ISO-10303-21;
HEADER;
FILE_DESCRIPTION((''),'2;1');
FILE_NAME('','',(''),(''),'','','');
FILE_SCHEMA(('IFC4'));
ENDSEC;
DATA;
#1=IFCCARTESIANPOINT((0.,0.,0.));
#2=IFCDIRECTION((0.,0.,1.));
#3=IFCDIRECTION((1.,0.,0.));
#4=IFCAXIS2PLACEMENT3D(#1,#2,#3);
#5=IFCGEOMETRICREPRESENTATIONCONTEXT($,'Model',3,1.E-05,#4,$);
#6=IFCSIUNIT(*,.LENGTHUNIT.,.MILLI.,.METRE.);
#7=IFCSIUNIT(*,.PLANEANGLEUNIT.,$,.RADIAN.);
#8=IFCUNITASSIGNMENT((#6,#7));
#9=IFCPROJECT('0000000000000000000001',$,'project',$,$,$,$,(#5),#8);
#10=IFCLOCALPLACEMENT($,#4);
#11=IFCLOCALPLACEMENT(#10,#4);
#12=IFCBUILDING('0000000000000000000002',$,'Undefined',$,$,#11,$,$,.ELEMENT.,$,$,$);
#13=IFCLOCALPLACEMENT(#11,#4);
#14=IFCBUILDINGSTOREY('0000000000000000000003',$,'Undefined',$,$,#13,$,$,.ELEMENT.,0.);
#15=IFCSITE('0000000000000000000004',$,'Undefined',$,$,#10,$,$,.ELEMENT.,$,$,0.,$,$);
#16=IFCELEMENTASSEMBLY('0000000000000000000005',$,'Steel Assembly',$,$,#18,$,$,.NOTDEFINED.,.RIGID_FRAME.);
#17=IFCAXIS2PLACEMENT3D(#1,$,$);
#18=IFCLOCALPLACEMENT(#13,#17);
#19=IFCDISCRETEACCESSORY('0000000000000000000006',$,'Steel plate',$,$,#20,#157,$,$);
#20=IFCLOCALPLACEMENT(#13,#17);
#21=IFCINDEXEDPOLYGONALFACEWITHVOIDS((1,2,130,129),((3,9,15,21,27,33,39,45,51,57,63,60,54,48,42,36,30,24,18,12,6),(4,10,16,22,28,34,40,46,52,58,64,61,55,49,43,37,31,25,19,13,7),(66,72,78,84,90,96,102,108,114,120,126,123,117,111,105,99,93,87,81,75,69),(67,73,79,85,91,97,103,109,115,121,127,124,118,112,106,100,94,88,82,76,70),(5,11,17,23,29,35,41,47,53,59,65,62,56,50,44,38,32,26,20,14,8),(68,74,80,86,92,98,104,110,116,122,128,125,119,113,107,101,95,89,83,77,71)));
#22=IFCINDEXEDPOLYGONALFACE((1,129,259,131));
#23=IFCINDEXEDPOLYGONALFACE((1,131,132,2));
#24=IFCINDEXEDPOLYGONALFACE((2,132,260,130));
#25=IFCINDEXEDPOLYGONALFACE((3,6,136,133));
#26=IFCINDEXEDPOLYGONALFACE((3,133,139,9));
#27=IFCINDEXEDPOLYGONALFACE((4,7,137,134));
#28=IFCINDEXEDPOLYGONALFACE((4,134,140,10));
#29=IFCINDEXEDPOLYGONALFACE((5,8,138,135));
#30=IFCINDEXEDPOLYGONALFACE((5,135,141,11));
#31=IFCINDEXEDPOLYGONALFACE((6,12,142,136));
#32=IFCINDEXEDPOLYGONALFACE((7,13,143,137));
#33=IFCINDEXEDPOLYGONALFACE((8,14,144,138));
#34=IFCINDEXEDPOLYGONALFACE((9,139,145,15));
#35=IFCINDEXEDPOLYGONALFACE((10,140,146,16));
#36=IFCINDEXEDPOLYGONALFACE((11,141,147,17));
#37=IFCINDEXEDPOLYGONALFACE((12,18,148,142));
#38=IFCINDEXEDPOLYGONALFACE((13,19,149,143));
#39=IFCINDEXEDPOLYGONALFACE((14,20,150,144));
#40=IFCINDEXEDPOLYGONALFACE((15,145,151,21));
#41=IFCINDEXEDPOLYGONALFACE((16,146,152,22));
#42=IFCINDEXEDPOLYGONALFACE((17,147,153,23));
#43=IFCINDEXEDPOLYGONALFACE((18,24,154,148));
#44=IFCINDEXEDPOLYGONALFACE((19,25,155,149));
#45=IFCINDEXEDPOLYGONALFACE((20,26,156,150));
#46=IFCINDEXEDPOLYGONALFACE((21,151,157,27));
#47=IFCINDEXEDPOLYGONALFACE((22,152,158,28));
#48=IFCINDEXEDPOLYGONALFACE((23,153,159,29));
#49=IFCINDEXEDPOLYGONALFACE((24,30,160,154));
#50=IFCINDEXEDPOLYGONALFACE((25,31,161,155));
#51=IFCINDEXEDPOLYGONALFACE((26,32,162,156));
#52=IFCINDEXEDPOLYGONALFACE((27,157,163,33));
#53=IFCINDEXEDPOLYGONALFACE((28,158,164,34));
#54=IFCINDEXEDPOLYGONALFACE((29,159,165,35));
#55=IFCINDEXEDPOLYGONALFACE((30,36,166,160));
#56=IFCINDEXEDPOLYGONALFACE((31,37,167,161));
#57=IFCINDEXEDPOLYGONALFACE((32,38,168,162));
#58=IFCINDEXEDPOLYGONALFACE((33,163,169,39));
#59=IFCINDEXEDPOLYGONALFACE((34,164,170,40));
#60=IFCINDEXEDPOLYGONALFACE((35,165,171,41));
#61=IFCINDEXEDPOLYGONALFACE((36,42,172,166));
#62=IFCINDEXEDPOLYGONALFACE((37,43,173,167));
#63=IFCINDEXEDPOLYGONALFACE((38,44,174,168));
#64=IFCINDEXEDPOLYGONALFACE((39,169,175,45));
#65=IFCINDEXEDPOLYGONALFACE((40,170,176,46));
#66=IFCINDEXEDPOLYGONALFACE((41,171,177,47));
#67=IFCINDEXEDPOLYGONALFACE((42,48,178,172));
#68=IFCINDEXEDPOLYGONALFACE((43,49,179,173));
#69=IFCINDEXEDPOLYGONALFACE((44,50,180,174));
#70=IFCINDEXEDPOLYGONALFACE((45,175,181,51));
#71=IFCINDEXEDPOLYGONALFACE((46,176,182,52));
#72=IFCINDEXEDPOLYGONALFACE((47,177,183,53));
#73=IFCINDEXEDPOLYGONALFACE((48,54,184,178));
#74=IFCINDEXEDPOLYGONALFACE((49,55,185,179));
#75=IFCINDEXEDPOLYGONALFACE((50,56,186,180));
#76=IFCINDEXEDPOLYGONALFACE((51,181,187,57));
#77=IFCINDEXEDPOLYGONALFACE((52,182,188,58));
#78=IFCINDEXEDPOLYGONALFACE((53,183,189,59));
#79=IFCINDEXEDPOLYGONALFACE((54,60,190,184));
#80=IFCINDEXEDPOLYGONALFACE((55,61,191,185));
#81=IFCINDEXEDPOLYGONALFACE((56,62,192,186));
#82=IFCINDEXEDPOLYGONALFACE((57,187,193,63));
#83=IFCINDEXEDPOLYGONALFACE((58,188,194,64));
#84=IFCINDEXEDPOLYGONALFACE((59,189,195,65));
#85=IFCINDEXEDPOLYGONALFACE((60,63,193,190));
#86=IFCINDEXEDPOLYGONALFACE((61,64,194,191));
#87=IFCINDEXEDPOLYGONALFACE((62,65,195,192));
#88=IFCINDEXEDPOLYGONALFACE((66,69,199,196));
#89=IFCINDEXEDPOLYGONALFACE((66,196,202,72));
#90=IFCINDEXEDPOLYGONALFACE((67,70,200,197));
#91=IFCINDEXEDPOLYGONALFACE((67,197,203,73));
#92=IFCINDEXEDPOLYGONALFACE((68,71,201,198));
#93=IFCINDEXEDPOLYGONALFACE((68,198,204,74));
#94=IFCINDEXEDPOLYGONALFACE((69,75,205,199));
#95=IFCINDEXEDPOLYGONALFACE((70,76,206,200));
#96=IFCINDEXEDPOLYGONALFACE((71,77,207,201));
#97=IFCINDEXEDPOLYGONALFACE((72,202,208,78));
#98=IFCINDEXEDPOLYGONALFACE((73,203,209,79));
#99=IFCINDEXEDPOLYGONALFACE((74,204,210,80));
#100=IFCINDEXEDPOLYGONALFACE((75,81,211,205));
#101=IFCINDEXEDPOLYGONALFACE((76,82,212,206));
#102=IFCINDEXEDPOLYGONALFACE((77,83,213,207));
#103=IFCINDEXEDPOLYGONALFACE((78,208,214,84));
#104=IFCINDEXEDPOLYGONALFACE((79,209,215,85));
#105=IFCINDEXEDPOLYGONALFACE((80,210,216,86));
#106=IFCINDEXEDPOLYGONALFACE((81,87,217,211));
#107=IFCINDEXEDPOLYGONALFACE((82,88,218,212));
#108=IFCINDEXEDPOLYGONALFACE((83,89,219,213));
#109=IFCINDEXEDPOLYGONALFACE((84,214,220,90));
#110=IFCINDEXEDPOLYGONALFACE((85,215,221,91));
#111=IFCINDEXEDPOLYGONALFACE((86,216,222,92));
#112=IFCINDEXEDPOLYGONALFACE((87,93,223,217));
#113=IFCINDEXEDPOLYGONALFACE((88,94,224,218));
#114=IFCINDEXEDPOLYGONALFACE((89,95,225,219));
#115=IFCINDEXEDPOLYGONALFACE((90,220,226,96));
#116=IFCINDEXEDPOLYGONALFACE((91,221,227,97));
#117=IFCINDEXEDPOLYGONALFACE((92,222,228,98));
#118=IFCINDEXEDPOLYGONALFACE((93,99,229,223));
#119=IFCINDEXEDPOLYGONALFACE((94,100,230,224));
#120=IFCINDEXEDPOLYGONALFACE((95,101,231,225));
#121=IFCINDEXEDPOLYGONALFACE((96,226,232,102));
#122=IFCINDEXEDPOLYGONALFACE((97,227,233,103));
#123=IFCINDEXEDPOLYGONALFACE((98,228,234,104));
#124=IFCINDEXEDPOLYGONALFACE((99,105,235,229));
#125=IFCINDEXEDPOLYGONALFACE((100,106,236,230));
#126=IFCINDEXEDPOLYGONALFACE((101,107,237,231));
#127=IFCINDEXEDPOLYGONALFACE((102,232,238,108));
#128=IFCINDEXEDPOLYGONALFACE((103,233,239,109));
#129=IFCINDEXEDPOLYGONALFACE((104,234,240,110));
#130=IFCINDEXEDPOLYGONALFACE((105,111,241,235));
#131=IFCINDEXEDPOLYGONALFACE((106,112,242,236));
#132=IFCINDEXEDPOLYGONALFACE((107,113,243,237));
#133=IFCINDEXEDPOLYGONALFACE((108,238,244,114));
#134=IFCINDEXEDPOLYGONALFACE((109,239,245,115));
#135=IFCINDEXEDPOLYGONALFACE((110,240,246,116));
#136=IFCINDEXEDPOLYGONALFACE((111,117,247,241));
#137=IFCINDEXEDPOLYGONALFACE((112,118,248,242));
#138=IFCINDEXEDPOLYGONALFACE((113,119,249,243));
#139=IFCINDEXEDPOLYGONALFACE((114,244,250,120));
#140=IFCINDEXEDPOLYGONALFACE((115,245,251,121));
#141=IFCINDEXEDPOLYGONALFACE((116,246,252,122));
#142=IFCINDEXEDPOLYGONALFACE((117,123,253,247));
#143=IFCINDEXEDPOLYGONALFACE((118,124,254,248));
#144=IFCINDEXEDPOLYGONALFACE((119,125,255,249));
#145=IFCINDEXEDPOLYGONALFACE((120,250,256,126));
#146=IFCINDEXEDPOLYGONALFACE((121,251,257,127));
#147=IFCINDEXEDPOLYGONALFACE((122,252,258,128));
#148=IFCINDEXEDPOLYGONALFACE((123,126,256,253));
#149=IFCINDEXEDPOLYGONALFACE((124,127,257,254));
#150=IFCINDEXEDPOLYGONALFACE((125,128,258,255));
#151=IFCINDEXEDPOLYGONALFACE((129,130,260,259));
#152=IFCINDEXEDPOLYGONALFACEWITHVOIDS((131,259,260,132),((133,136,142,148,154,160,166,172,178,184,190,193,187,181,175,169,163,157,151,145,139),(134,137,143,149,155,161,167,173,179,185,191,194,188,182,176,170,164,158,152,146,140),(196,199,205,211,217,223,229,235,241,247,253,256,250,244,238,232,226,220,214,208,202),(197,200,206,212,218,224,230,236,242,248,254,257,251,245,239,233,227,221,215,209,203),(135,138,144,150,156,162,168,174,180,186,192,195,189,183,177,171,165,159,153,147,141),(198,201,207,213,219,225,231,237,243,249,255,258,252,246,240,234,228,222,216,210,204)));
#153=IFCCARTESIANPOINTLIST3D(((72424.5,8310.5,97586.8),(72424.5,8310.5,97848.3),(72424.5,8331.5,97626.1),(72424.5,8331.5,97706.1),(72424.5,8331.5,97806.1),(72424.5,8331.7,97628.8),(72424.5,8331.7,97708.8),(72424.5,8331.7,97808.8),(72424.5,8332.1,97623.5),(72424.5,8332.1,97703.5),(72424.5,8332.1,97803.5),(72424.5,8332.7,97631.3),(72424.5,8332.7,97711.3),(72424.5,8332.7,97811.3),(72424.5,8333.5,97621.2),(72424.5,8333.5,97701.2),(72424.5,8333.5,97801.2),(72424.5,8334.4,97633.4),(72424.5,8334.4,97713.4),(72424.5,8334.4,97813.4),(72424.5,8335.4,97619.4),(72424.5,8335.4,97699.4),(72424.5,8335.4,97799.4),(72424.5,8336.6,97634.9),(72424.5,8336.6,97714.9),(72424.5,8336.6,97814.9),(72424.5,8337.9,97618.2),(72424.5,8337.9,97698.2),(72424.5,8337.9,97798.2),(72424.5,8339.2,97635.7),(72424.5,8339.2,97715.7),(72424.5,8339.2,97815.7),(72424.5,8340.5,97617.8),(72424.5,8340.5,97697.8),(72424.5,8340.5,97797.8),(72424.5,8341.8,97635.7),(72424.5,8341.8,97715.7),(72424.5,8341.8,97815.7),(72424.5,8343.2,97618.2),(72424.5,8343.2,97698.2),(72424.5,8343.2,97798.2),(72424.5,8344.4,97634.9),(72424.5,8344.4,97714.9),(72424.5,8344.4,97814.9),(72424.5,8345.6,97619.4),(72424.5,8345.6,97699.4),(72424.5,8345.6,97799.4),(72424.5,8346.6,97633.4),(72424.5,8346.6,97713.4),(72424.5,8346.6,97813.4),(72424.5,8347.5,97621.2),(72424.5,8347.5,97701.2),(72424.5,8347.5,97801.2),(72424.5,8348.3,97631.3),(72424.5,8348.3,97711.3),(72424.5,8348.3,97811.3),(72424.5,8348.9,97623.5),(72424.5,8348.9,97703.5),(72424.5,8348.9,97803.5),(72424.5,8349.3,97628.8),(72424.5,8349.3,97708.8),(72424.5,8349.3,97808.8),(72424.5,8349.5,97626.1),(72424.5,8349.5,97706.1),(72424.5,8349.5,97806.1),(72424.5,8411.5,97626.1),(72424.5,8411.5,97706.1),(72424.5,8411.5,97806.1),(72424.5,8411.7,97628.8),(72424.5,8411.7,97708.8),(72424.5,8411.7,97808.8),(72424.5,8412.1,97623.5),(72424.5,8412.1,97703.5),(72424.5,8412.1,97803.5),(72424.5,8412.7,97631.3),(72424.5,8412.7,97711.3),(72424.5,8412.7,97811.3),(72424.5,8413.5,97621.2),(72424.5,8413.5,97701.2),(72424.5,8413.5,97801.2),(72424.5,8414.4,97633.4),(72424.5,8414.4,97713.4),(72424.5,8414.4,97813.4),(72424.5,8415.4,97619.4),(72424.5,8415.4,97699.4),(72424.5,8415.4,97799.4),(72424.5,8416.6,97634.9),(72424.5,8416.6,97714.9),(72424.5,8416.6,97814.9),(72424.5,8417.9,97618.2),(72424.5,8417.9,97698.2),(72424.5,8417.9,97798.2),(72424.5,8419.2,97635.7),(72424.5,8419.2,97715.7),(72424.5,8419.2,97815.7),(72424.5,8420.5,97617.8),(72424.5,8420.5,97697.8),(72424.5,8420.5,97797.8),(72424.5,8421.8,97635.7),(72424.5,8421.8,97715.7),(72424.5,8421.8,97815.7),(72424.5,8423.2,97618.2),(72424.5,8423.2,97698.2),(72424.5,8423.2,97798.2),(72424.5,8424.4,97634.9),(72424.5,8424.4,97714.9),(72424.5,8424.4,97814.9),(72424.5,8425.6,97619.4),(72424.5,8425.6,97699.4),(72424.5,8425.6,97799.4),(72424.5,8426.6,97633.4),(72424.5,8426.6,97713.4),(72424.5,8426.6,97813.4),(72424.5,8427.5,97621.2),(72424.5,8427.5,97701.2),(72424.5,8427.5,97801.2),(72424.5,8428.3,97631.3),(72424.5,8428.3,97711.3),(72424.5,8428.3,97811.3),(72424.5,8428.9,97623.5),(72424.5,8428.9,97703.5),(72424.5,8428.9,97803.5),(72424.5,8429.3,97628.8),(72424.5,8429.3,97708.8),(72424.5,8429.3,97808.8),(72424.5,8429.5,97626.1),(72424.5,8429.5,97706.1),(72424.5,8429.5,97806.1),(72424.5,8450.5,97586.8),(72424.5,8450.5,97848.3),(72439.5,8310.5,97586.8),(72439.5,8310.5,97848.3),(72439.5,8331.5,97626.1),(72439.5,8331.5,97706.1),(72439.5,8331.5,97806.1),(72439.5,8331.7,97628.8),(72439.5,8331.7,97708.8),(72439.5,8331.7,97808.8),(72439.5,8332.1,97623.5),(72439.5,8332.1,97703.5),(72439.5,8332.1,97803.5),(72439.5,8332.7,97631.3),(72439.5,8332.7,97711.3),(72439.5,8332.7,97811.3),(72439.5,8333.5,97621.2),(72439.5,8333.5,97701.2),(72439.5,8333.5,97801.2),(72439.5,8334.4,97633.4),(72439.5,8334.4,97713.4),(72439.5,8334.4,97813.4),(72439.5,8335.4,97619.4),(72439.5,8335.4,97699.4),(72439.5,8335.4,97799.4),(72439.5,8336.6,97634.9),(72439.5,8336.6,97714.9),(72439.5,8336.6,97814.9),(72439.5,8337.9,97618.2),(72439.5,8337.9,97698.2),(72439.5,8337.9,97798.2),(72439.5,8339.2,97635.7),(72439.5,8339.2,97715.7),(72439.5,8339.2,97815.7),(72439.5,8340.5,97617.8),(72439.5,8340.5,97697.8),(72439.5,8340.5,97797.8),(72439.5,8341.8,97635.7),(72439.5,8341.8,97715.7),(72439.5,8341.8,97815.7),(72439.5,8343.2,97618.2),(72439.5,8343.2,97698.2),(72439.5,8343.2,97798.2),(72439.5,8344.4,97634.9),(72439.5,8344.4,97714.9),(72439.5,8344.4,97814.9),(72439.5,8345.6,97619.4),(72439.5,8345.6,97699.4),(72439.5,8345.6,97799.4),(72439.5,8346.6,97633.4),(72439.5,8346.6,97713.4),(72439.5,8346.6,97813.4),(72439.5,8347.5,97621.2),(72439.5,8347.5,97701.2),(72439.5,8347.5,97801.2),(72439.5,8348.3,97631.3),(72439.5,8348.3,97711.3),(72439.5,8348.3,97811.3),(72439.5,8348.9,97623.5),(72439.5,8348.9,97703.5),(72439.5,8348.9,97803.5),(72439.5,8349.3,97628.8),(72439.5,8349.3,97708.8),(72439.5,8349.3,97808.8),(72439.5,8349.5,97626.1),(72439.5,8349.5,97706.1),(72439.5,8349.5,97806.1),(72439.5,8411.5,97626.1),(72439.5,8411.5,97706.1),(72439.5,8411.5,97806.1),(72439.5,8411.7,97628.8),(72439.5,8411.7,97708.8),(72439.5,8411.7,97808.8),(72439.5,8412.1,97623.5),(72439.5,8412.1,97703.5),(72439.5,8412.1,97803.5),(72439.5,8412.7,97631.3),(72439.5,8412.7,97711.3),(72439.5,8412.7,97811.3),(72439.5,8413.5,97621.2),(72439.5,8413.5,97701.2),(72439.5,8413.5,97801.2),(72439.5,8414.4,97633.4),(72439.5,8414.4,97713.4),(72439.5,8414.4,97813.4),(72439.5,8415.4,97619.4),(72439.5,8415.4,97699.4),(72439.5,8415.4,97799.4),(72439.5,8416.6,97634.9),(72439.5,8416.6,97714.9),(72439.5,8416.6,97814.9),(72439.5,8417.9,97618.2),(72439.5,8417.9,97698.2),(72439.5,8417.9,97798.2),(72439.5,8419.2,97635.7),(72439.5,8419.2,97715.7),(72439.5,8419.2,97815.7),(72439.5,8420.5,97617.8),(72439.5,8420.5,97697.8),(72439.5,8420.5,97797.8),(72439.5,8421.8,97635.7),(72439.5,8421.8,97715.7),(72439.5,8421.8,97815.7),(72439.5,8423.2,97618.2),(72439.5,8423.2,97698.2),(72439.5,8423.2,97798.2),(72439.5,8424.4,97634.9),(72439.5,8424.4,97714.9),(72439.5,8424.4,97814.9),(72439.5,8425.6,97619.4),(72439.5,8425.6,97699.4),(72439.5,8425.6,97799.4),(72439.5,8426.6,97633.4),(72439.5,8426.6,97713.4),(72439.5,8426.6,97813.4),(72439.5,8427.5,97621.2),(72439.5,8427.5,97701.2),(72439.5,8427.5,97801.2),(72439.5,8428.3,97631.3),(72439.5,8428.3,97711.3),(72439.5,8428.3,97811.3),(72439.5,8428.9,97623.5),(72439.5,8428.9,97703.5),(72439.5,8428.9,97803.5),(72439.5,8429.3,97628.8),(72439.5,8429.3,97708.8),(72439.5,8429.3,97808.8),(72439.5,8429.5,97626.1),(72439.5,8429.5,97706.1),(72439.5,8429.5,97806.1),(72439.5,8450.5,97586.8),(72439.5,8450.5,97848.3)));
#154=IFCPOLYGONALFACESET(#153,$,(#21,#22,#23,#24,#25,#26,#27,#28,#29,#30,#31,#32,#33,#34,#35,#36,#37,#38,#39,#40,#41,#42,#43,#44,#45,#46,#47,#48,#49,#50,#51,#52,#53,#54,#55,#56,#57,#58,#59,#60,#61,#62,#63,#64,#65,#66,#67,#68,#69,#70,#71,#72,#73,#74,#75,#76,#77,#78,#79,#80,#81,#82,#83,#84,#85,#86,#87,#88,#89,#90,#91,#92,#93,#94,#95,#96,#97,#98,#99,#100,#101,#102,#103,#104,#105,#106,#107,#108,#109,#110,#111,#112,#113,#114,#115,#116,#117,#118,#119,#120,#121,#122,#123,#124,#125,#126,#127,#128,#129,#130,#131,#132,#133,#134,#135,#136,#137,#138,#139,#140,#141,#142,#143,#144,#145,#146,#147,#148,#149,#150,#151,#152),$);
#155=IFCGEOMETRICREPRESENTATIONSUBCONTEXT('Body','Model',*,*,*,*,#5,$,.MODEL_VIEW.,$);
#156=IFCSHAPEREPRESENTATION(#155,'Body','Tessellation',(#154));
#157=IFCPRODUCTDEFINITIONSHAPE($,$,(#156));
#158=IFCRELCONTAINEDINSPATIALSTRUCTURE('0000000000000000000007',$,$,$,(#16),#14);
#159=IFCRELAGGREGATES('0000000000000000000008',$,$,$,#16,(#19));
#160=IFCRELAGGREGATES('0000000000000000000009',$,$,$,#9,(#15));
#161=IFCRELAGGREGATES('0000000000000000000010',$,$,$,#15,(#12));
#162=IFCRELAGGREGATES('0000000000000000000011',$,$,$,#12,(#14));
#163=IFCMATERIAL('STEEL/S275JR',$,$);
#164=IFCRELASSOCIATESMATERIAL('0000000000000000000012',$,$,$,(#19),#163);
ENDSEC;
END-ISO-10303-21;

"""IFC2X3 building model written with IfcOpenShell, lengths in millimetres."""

from ifc_helpers import new_model, si_unit, frame, origin_with_axes, origin_2d_with_axis, place, context, subcontext, project, spatial, polyline, circle, outline, extrude, source, transform, mapped, material, element, aggregate, save


model = new_model("IFC2X3")

# Units and contexts
model_context = context("Model", 3, precision=1e-05, world=origin_with_axes())
body_context = subcontext(model_context, "Body", "Model", "MODEL_VIEW")
ifc_project = project(units=[si_unit("LENGTHUNIT", "METRE", prefix="MILLI"), si_unit("PLANEANGLEUNIT", "RADIAN")], contexts=[model_context])

# Site, building, storey
site_placement = place(None, origin_with_axes())
site = spatial("IfcSite", under=ifc_project, at=site_placement, Name="Undefined", CompositionType="ELEMENT", RefElevation=0.0)
building_placement = place(site_placement, origin_with_axes())
building = spatial("IfcBuilding", under=site, at=building_placement, Name="Undefined", CompositionType="ELEMENT")
storey_placement = place(building_placement, origin_with_axes())
storey = spatial("IfcBuildingStorey", under=building, at=storey_placement, Name="Undefined", CompositionType="ELEMENT", Elevation=0.0)

# Shared definitions
ifc_material_1 = material(Name="STEEL/S275JR")

# Element assembly
assembly_1_placement = place(storey_placement, origin_with_axes())
assembly_1 = element("IfcElementAssembly", 1, at=assembly_1_placement, inside=storey, Name="Steel Assembly", AssemblyPlace="NOTDEFINED", PredefinedType="RIGID_FRAME")

# Shared definitions
shared_shape_1 = source(origin_with_axes(), body_context, "Body", "SweptSolid", [
    extrude(circle(Radius=9.0, at=origin_2d_with_axis()), frame((0.0, -15.1, 0.0), z_axis=(0.0, 1.0, 0.0), x_axis=(1.0, 0.0, 0.0)), (0.0, 0.0, 1.0), 30.3),
])

# Discrete accessory, opening
discrete_accessory_1_placement = place(assembly_1_placement, frame((72432.0, 8310.5, 97848.3), z_axis=(-1.0, 0.0, 0.0), x_axis=(0.0, 1.0, 0.0)))
discrete_accessory_1 = element("IfcDiscreteAccessory", 2, at=discrete_accessory_1_placement, material=ifc_material_1, Name="Steel plate", context=body_context, shape_type="SweptSolid", body=[
    extrude(outline(polyline([(0.0, 0.0), (140.0, 0.0), (140.0, 261.5), (0.0, 261.5), (0.0, 0.0)])), frame((0.0, 0.0, -7.5), z_axis=(0.0, 0.0, 1.0), x_axis=(1.0, 0.0, 0.0)), (0.0, 0.0, 1.0), 15.0),
])
opening_1_placement = place(assembly_1_placement, frame((72439.5, 8380.5, 97806.8), z_axis=(0.0, -1.0, 0.0), x_axis=(0.0, 0.0, -1.0)))
element("IfcOpeningElement", 3, at=opening_1_placement, cuts=discrete_accessory_1, ObjectType="Opening", context=body_context, shape_type="MappedRepresentation", body=[
    mapped(shared_shape_1, transform((0.0, 0.0, -40.0))),
    mapped(shared_shape_1, transform((100.0, 0.0, -40.0))),
    mapped(shared_shape_1, transform((180.0, 0.0, -40.0))),
    mapped(shared_shape_1, transform((0.0, 0.0, 40.0))),
    mapped(shared_shape_1, transform((100.0, 0.0, 40.0))),
    mapped(shared_shape_1, transform((180.0, 0.0, 40.0))),
])
aggregate(assembly_1, [discrete_accessory_1])

save(model, "model.ifc")
